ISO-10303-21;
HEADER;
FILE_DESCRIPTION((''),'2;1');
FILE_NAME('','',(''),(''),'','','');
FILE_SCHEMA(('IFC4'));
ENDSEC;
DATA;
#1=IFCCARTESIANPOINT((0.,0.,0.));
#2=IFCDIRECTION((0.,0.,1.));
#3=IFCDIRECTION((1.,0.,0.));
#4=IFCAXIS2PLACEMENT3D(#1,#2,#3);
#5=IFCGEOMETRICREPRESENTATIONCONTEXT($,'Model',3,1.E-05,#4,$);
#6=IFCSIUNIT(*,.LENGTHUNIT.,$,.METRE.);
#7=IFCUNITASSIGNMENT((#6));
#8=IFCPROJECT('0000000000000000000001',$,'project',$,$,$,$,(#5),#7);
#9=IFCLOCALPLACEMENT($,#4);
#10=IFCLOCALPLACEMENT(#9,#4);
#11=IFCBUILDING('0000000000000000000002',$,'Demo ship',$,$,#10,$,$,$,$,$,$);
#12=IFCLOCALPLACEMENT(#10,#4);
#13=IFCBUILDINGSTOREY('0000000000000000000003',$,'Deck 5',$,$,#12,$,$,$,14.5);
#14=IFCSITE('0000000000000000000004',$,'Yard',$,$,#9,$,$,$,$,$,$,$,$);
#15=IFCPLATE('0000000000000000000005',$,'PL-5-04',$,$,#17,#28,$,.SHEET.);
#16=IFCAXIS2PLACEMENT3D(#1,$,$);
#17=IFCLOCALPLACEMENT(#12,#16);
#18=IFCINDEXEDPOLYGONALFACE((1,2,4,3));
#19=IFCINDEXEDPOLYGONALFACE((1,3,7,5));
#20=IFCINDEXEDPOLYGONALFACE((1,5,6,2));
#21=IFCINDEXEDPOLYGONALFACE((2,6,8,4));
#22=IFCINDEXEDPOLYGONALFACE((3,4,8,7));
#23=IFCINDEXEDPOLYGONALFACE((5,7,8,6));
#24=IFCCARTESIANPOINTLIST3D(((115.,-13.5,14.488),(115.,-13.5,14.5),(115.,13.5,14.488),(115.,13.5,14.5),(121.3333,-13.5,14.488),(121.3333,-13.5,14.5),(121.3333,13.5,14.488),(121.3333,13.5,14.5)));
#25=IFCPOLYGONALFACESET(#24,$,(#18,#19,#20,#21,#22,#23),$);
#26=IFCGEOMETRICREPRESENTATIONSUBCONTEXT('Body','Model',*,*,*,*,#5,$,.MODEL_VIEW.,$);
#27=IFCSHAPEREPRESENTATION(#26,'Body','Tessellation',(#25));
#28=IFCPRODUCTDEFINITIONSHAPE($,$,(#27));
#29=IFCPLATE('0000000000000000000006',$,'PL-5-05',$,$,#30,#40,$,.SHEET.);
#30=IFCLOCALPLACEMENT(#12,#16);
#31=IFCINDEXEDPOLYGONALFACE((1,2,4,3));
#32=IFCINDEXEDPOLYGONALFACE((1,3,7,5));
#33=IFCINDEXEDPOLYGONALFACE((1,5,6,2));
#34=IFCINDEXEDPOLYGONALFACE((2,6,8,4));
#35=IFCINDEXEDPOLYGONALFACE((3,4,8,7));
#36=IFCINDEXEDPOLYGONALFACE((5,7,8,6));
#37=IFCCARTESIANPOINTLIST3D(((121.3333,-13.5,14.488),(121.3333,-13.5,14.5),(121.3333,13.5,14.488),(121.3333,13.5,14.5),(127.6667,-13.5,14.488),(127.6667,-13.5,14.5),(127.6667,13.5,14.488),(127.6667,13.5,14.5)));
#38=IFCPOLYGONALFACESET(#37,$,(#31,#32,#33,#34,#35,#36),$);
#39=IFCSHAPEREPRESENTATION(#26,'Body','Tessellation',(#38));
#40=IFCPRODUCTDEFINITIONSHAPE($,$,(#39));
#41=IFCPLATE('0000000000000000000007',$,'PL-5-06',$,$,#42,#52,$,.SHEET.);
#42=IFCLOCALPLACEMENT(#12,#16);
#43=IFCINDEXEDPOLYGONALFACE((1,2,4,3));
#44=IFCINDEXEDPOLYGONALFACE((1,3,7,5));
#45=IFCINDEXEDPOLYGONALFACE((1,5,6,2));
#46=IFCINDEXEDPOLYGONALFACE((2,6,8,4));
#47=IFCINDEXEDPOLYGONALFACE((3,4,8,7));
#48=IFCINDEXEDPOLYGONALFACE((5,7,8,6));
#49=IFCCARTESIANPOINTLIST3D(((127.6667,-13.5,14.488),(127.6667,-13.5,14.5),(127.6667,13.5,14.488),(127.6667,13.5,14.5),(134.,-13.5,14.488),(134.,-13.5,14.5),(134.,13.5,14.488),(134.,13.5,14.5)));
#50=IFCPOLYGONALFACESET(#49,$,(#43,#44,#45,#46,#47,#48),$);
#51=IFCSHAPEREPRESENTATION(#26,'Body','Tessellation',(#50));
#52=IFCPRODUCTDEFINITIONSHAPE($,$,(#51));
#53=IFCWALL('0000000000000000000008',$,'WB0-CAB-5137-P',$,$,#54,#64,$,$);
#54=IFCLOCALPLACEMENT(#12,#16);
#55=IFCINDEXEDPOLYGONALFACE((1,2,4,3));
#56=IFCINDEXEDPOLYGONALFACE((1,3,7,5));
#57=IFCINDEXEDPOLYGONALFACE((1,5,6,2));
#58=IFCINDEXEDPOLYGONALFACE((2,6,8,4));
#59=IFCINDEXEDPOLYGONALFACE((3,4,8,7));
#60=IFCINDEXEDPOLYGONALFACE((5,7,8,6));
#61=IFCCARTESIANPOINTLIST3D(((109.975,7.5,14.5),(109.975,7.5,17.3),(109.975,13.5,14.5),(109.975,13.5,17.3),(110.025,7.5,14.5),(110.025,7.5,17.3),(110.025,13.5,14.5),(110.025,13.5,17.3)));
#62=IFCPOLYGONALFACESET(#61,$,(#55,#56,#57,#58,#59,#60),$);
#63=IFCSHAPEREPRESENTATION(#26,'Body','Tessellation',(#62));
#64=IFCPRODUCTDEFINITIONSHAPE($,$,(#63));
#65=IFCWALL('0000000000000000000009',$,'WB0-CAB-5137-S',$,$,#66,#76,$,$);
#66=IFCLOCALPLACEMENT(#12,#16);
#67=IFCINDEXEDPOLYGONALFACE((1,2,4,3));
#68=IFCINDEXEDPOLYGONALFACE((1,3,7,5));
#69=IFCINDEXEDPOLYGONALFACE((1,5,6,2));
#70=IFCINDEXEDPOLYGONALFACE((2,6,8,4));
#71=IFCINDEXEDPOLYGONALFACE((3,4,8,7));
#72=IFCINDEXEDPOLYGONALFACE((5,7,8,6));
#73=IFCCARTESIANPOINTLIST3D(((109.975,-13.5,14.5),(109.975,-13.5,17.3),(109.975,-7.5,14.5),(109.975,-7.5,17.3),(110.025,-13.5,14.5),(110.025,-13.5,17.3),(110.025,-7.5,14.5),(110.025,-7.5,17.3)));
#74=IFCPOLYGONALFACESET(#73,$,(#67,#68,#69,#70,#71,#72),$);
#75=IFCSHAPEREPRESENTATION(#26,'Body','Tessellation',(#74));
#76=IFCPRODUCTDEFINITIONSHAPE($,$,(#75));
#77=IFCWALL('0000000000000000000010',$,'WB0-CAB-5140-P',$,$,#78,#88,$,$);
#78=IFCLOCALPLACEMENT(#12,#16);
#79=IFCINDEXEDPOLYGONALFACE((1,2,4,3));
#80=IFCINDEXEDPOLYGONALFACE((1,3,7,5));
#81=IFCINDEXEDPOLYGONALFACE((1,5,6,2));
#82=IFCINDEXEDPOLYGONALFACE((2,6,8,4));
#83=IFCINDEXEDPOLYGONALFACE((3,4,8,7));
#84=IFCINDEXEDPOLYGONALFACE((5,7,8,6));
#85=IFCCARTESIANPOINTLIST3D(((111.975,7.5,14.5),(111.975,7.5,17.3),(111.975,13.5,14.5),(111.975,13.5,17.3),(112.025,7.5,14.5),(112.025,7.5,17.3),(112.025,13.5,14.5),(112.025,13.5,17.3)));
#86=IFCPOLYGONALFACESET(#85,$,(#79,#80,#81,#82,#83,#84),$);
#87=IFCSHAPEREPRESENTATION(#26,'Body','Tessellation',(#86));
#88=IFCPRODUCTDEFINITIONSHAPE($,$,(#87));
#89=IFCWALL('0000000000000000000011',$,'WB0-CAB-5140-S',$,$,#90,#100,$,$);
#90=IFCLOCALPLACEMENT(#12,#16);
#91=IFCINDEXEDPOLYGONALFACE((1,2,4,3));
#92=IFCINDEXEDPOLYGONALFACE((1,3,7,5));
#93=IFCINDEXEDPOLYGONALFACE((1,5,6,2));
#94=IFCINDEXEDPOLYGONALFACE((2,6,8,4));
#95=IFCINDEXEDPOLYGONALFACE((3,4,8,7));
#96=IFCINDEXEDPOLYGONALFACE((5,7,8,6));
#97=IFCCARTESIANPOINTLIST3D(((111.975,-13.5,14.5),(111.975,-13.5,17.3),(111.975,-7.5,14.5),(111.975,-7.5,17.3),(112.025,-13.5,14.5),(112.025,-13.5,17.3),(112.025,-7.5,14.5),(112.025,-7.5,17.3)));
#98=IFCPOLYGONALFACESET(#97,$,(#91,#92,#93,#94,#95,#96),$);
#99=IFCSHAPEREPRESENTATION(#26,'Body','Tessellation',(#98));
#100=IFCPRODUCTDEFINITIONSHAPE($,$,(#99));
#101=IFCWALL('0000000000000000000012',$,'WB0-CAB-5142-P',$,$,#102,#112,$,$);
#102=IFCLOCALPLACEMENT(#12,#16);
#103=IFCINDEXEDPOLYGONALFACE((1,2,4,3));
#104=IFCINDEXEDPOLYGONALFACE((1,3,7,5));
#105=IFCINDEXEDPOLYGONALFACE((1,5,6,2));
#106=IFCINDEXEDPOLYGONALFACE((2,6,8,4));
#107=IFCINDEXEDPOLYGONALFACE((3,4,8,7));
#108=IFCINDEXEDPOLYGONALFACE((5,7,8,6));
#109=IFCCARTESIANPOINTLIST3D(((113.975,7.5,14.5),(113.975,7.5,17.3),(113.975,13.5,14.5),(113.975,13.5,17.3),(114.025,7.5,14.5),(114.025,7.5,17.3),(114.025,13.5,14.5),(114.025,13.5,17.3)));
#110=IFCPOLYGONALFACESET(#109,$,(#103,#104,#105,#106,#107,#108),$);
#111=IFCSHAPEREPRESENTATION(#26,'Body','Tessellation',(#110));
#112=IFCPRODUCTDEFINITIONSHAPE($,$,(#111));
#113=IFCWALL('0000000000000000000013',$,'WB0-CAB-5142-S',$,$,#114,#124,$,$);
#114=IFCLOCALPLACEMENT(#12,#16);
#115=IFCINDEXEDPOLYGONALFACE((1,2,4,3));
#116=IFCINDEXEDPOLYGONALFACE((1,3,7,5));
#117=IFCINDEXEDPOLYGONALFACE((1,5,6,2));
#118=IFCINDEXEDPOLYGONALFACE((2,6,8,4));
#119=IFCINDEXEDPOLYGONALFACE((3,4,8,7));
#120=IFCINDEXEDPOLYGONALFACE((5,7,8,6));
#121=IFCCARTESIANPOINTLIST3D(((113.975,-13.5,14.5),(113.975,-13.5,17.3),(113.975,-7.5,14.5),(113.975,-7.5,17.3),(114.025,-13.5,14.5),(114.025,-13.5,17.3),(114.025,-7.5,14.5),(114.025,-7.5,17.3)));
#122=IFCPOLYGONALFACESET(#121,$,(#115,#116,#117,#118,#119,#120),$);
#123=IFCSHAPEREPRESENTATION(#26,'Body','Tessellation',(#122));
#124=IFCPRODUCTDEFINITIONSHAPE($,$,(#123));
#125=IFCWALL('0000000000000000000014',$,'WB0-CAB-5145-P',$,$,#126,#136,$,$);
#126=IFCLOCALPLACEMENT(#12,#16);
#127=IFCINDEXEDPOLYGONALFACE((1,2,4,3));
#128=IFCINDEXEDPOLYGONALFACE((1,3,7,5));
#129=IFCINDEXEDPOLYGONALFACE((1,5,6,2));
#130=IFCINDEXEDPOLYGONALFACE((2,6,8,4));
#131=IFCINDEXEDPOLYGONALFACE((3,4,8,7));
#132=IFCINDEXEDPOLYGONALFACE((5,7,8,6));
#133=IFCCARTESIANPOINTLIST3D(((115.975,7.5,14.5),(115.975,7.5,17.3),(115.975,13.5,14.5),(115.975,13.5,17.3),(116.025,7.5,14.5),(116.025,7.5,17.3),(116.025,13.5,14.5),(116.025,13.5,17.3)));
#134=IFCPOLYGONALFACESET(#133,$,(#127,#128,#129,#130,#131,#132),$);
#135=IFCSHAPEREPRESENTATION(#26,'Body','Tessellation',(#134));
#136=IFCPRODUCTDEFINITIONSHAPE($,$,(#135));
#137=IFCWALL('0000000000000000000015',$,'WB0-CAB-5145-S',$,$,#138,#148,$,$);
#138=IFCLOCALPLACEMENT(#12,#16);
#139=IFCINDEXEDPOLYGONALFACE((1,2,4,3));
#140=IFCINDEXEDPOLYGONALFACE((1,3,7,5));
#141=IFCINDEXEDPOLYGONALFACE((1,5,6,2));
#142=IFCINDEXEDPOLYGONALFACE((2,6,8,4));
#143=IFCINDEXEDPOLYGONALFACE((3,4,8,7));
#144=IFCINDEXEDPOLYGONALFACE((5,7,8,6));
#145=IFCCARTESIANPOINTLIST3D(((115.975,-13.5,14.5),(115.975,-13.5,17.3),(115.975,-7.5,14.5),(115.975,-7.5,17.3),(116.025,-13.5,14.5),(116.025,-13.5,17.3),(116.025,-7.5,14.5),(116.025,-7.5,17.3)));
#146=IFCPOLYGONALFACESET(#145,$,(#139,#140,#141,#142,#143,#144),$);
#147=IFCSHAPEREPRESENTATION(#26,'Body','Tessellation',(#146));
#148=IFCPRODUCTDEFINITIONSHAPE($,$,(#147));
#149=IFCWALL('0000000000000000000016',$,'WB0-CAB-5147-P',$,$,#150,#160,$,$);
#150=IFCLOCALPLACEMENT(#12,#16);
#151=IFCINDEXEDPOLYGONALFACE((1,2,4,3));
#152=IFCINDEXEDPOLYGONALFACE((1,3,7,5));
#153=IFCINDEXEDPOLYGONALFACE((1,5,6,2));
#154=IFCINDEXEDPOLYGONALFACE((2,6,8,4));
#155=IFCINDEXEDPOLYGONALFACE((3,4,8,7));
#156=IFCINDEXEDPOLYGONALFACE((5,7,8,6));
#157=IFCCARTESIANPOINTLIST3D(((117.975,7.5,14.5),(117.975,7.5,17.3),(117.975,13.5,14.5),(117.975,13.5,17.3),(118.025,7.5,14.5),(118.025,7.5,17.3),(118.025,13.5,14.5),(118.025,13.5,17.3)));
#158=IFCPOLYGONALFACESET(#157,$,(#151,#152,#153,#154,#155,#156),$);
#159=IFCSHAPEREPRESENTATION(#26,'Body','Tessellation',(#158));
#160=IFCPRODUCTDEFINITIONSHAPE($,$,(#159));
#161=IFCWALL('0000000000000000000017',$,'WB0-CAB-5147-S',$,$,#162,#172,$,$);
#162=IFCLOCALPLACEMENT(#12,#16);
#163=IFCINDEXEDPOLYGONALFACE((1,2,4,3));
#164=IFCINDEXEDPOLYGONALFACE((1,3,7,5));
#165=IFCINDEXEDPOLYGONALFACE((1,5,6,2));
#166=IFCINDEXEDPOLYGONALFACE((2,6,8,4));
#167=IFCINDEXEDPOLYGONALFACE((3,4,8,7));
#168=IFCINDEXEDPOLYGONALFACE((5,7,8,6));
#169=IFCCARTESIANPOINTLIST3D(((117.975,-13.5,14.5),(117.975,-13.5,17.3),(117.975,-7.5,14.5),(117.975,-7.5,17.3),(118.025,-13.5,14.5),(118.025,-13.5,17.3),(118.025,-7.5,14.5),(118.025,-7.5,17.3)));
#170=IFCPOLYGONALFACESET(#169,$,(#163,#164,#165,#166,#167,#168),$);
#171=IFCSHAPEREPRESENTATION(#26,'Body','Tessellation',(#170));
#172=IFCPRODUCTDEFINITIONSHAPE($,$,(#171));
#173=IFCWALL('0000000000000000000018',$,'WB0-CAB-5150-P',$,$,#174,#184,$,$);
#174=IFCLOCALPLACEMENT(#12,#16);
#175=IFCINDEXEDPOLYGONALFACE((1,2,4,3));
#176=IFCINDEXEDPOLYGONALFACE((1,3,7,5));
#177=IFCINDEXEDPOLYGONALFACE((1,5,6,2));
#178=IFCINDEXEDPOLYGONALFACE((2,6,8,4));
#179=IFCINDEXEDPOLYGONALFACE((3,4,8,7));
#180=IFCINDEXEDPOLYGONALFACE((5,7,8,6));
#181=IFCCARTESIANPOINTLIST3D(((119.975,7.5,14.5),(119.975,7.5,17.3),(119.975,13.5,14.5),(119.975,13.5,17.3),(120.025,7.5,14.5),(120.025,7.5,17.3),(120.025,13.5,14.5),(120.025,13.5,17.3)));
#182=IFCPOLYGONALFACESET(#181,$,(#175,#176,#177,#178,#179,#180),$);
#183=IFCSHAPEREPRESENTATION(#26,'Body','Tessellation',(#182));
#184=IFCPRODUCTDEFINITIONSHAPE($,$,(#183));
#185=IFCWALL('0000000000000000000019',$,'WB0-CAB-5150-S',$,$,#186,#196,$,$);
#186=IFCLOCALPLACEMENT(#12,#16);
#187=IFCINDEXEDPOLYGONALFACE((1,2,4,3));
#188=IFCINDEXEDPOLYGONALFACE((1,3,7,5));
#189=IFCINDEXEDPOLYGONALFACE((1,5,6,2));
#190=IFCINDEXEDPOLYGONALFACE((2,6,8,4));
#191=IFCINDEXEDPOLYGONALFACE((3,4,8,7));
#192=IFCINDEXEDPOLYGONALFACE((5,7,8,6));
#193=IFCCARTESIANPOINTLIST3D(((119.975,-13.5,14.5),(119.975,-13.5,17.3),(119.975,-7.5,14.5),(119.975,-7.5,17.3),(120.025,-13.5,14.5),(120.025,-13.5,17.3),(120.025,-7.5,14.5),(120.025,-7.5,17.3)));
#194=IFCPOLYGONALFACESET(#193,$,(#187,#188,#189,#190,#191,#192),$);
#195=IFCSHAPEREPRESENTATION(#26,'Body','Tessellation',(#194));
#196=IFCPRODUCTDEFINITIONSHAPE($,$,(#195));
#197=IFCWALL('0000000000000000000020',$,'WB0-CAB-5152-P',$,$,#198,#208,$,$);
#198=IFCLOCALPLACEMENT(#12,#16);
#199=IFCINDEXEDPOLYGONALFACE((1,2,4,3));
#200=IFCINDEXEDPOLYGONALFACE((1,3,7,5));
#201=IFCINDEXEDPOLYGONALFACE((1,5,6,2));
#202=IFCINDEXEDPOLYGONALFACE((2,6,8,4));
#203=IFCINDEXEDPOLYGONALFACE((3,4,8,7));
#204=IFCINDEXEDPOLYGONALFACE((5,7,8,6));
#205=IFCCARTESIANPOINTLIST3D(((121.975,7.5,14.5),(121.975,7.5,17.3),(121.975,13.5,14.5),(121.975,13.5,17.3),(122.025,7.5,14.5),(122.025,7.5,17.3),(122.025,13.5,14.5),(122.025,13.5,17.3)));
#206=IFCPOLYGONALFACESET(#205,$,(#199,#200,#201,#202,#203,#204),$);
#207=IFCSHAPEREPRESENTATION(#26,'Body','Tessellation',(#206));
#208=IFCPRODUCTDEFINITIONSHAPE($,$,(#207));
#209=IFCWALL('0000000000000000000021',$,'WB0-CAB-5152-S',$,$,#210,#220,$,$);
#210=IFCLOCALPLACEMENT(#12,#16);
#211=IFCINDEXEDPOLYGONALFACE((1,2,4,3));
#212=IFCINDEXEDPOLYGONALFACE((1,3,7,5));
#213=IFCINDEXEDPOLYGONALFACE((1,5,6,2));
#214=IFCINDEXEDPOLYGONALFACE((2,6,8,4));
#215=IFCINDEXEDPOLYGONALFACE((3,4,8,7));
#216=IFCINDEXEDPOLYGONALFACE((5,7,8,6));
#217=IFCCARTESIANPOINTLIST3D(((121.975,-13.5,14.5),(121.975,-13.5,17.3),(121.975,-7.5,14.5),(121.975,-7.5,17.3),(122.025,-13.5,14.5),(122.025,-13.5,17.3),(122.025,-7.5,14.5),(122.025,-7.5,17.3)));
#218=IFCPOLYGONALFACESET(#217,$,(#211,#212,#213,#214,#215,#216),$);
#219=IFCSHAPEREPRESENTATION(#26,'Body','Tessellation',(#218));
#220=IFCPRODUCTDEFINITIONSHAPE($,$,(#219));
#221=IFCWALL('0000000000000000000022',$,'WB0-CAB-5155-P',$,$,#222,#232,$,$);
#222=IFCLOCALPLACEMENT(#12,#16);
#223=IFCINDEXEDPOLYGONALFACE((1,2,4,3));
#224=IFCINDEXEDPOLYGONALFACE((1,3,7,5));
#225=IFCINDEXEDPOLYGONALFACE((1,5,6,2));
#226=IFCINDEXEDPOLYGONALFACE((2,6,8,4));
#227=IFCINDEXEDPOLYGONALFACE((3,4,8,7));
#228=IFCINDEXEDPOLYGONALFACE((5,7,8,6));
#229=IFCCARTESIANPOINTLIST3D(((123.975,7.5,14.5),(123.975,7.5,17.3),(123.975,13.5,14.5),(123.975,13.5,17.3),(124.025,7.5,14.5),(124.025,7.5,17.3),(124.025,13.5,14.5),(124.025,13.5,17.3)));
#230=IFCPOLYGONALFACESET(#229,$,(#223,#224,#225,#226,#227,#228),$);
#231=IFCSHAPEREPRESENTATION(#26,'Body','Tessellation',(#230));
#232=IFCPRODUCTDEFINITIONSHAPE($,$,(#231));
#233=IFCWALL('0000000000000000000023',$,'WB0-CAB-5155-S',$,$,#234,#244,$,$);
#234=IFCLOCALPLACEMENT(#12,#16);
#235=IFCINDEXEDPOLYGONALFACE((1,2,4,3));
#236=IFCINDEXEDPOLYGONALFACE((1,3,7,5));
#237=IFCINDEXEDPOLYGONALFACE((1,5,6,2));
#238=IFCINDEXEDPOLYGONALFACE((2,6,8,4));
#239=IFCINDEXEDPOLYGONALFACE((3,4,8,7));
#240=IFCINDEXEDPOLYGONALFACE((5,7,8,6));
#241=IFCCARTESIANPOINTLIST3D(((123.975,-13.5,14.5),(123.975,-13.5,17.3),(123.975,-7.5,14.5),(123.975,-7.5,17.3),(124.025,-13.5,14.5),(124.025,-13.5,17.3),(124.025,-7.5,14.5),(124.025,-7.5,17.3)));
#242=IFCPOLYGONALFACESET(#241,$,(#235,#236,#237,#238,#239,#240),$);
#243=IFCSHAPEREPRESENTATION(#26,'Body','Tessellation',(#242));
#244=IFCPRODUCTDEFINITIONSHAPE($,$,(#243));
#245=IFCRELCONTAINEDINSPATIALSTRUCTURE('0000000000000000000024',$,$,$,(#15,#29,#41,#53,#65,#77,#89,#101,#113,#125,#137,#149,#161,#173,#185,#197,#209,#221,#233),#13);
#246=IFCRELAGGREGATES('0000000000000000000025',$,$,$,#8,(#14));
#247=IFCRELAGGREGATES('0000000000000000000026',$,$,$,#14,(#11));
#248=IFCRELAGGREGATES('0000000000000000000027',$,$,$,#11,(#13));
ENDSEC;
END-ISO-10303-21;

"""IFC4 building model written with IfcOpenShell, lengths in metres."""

from ifc_helpers import new_model, si_unit, frame, frame_2d, origin, origin_with_axes, place, context, subcontext, project, spatial, rectangle, extrude, element, save


model = new_model("IFC4")

# Units and contexts
model_context = context("Model", 3, precision=1e-05, world=origin_with_axes())
body_context = subcontext(model_context, "Body", "Model", "MODEL_VIEW")
ifc_project = project(units=[si_unit("LENGTHUNIT", "METRE")], contexts=[model_context])

# Site, building, storey
site_placement = place(None, origin_with_axes())
site = spatial("IfcSite", under=ifc_project, at=site_placement, Name="Yard")
building_placement = place(site_placement, origin_with_axes())
building = spatial("IfcBuilding", under=site, at=building_placement, Name="Demo ship")
storey_placement = place(building_placement, origin_with_axes())
storey = spatial("IfcBuildingStorey", under=building, at=storey_placement, Name="Deck 5", Elevation=14.5)

# Plates
plate_1_placement = place(storey_placement, frame((115.0, -13.5, 14.488), z_axis=(0.0, 0.0, 1.0), x_axis=(1.0, 0.0, 0.0)))
element("IfcPlate", 1, at=plate_1_placement, inside=storey, Name="PL-5-04", PredefinedType="SHEET", context=body_context, shape_type="SweptSolid", body=[
    extrude(rectangle(XDim=6.3333, YDim=27.0, at=frame_2d((3.1666, 13.5))), origin(), (0.0, 0.0, 1.0), 0.012),
])
plate_2_placement = place(storey_placement, frame((121.3333, -13.5, 14.488), z_axis=(0.0, 0.0, 1.0), x_axis=(1.0, 0.0, 0.0)))
element("IfcPlate", 2, at=plate_2_placement, inside=storey, Name="PL-5-05", PredefinedType="SHEET", context=body_context, shape_type="SweptSolid", body=[
    extrude(rectangle(XDim=6.3334, YDim=27.0, at=frame_2d((3.1667, 13.5))), origin(), (0.0, 0.0, 1.0), 0.012),
])
plate_3_placement = place(storey_placement, frame((127.6667, -13.5, 14.488), z_axis=(0.0, 0.0, 1.0), x_axis=(1.0, 0.0, 0.0)))
element("IfcPlate", 3, at=plate_3_placement, inside=storey, Name="PL-5-06", PredefinedType="SHEET", context=body_context, shape_type="SweptSolid", body=[
    extrude(rectangle(XDim=6.3333, YDim=27.0, at=frame_2d((3.1666, 13.5))), origin(), (0.0, 0.0, 1.0), 0.012),
])

# Walls
for number, where, z_axis, x_axis, name in (
    (4, (109.975, 7.5, 14.5), (0.0, 0.0, 1.0), (1.0, 0.0, 0.0), "WB0-CAB-5137-P"),
    (5, (109.975, -13.5, 14.5), (0.0, 0.0, 1.0), (1.0, 0.0, 0.0), "WB0-CAB-5137-S"),
    (6, (111.975, 7.5, 14.5), (0.0, 0.0, 1.0), (1.0, 0.0, 0.0), "WB0-CAB-5140-P"),
    (7, (111.975, -13.5, 14.5), (0.0, 0.0, 1.0), (1.0, 0.0, 0.0), "WB0-CAB-5140-S"),
    (8, (113.975, 7.5, 14.5), (0.0, 0.0, 1.0), (1.0, 0.0, 0.0), "WB0-CAB-5142-P"),
    (9, (113.975, -13.5, 14.5), (0.0, 0.0, 1.0), (1.0, 0.0, 0.0), "WB0-CAB-5142-S"),
    (10, (115.975, 7.5, 14.5), (0.0, 0.0, 1.0), (1.0, 0.0, 0.0), "WB0-CAB-5145-P"),
    (11, (115.975, -13.5, 14.5), (0.0, 0.0, 1.0), (1.0, 0.0, 0.0), "WB0-CAB-5145-S"),
    (12, (117.975, 7.5, 14.5), (0.0, 0.0, 1.0), (1.0, 0.0, 0.0), "WB0-CAB-5147-P"),
    (13, (117.975, -13.5, 14.5), (0.0, 0.0, 1.0), (1.0, 0.0, 0.0), "WB0-CAB-5147-S"),
    (14, (119.975, 7.5, 14.5), (0.0, 0.0, 1.0), (1.0, 0.0, 0.0), "WB0-CAB-5150-P"),
    (15, (119.975, -13.5, 14.5), (0.0, 0.0, 1.0), (1.0, 0.0, 0.0), "WB0-CAB-5150-S"),
    (16, (121.975, 7.5, 14.5), (0.0, 0.0, 1.0), (1.0, 0.0, 0.0), "WB0-CAB-5152-P"),
    (17, (121.975, -13.5, 14.5), (0.0, 0.0, 1.0), (1.0, 0.0, 0.0), "WB0-CAB-5152-S"),
    (18, (123.975, 7.5, 14.5), (0.0, 0.0, 1.0), (1.0, 0.0, 0.0), "WB0-CAB-5155-P"),
    (19, (123.975, -13.5, 14.5), (0.0, 0.0, 1.0), (1.0, 0.0, 0.0), "WB0-CAB-5155-S"),
):
    element("IfcWall", number, at=place(storey_placement, frame(where, z_axis=z_axis, x_axis=x_axis)), inside=storey, Name=name, context=body_context, shape_type="SweptSolid", body=[
        extrude(rectangle(XDim=0.05, YDim=6.0, at=frame_2d((0.025, 3.0))), origin(), (0.0, 0.0, 1.0), 2.8),
    ])

save(model, "model.ifc")
